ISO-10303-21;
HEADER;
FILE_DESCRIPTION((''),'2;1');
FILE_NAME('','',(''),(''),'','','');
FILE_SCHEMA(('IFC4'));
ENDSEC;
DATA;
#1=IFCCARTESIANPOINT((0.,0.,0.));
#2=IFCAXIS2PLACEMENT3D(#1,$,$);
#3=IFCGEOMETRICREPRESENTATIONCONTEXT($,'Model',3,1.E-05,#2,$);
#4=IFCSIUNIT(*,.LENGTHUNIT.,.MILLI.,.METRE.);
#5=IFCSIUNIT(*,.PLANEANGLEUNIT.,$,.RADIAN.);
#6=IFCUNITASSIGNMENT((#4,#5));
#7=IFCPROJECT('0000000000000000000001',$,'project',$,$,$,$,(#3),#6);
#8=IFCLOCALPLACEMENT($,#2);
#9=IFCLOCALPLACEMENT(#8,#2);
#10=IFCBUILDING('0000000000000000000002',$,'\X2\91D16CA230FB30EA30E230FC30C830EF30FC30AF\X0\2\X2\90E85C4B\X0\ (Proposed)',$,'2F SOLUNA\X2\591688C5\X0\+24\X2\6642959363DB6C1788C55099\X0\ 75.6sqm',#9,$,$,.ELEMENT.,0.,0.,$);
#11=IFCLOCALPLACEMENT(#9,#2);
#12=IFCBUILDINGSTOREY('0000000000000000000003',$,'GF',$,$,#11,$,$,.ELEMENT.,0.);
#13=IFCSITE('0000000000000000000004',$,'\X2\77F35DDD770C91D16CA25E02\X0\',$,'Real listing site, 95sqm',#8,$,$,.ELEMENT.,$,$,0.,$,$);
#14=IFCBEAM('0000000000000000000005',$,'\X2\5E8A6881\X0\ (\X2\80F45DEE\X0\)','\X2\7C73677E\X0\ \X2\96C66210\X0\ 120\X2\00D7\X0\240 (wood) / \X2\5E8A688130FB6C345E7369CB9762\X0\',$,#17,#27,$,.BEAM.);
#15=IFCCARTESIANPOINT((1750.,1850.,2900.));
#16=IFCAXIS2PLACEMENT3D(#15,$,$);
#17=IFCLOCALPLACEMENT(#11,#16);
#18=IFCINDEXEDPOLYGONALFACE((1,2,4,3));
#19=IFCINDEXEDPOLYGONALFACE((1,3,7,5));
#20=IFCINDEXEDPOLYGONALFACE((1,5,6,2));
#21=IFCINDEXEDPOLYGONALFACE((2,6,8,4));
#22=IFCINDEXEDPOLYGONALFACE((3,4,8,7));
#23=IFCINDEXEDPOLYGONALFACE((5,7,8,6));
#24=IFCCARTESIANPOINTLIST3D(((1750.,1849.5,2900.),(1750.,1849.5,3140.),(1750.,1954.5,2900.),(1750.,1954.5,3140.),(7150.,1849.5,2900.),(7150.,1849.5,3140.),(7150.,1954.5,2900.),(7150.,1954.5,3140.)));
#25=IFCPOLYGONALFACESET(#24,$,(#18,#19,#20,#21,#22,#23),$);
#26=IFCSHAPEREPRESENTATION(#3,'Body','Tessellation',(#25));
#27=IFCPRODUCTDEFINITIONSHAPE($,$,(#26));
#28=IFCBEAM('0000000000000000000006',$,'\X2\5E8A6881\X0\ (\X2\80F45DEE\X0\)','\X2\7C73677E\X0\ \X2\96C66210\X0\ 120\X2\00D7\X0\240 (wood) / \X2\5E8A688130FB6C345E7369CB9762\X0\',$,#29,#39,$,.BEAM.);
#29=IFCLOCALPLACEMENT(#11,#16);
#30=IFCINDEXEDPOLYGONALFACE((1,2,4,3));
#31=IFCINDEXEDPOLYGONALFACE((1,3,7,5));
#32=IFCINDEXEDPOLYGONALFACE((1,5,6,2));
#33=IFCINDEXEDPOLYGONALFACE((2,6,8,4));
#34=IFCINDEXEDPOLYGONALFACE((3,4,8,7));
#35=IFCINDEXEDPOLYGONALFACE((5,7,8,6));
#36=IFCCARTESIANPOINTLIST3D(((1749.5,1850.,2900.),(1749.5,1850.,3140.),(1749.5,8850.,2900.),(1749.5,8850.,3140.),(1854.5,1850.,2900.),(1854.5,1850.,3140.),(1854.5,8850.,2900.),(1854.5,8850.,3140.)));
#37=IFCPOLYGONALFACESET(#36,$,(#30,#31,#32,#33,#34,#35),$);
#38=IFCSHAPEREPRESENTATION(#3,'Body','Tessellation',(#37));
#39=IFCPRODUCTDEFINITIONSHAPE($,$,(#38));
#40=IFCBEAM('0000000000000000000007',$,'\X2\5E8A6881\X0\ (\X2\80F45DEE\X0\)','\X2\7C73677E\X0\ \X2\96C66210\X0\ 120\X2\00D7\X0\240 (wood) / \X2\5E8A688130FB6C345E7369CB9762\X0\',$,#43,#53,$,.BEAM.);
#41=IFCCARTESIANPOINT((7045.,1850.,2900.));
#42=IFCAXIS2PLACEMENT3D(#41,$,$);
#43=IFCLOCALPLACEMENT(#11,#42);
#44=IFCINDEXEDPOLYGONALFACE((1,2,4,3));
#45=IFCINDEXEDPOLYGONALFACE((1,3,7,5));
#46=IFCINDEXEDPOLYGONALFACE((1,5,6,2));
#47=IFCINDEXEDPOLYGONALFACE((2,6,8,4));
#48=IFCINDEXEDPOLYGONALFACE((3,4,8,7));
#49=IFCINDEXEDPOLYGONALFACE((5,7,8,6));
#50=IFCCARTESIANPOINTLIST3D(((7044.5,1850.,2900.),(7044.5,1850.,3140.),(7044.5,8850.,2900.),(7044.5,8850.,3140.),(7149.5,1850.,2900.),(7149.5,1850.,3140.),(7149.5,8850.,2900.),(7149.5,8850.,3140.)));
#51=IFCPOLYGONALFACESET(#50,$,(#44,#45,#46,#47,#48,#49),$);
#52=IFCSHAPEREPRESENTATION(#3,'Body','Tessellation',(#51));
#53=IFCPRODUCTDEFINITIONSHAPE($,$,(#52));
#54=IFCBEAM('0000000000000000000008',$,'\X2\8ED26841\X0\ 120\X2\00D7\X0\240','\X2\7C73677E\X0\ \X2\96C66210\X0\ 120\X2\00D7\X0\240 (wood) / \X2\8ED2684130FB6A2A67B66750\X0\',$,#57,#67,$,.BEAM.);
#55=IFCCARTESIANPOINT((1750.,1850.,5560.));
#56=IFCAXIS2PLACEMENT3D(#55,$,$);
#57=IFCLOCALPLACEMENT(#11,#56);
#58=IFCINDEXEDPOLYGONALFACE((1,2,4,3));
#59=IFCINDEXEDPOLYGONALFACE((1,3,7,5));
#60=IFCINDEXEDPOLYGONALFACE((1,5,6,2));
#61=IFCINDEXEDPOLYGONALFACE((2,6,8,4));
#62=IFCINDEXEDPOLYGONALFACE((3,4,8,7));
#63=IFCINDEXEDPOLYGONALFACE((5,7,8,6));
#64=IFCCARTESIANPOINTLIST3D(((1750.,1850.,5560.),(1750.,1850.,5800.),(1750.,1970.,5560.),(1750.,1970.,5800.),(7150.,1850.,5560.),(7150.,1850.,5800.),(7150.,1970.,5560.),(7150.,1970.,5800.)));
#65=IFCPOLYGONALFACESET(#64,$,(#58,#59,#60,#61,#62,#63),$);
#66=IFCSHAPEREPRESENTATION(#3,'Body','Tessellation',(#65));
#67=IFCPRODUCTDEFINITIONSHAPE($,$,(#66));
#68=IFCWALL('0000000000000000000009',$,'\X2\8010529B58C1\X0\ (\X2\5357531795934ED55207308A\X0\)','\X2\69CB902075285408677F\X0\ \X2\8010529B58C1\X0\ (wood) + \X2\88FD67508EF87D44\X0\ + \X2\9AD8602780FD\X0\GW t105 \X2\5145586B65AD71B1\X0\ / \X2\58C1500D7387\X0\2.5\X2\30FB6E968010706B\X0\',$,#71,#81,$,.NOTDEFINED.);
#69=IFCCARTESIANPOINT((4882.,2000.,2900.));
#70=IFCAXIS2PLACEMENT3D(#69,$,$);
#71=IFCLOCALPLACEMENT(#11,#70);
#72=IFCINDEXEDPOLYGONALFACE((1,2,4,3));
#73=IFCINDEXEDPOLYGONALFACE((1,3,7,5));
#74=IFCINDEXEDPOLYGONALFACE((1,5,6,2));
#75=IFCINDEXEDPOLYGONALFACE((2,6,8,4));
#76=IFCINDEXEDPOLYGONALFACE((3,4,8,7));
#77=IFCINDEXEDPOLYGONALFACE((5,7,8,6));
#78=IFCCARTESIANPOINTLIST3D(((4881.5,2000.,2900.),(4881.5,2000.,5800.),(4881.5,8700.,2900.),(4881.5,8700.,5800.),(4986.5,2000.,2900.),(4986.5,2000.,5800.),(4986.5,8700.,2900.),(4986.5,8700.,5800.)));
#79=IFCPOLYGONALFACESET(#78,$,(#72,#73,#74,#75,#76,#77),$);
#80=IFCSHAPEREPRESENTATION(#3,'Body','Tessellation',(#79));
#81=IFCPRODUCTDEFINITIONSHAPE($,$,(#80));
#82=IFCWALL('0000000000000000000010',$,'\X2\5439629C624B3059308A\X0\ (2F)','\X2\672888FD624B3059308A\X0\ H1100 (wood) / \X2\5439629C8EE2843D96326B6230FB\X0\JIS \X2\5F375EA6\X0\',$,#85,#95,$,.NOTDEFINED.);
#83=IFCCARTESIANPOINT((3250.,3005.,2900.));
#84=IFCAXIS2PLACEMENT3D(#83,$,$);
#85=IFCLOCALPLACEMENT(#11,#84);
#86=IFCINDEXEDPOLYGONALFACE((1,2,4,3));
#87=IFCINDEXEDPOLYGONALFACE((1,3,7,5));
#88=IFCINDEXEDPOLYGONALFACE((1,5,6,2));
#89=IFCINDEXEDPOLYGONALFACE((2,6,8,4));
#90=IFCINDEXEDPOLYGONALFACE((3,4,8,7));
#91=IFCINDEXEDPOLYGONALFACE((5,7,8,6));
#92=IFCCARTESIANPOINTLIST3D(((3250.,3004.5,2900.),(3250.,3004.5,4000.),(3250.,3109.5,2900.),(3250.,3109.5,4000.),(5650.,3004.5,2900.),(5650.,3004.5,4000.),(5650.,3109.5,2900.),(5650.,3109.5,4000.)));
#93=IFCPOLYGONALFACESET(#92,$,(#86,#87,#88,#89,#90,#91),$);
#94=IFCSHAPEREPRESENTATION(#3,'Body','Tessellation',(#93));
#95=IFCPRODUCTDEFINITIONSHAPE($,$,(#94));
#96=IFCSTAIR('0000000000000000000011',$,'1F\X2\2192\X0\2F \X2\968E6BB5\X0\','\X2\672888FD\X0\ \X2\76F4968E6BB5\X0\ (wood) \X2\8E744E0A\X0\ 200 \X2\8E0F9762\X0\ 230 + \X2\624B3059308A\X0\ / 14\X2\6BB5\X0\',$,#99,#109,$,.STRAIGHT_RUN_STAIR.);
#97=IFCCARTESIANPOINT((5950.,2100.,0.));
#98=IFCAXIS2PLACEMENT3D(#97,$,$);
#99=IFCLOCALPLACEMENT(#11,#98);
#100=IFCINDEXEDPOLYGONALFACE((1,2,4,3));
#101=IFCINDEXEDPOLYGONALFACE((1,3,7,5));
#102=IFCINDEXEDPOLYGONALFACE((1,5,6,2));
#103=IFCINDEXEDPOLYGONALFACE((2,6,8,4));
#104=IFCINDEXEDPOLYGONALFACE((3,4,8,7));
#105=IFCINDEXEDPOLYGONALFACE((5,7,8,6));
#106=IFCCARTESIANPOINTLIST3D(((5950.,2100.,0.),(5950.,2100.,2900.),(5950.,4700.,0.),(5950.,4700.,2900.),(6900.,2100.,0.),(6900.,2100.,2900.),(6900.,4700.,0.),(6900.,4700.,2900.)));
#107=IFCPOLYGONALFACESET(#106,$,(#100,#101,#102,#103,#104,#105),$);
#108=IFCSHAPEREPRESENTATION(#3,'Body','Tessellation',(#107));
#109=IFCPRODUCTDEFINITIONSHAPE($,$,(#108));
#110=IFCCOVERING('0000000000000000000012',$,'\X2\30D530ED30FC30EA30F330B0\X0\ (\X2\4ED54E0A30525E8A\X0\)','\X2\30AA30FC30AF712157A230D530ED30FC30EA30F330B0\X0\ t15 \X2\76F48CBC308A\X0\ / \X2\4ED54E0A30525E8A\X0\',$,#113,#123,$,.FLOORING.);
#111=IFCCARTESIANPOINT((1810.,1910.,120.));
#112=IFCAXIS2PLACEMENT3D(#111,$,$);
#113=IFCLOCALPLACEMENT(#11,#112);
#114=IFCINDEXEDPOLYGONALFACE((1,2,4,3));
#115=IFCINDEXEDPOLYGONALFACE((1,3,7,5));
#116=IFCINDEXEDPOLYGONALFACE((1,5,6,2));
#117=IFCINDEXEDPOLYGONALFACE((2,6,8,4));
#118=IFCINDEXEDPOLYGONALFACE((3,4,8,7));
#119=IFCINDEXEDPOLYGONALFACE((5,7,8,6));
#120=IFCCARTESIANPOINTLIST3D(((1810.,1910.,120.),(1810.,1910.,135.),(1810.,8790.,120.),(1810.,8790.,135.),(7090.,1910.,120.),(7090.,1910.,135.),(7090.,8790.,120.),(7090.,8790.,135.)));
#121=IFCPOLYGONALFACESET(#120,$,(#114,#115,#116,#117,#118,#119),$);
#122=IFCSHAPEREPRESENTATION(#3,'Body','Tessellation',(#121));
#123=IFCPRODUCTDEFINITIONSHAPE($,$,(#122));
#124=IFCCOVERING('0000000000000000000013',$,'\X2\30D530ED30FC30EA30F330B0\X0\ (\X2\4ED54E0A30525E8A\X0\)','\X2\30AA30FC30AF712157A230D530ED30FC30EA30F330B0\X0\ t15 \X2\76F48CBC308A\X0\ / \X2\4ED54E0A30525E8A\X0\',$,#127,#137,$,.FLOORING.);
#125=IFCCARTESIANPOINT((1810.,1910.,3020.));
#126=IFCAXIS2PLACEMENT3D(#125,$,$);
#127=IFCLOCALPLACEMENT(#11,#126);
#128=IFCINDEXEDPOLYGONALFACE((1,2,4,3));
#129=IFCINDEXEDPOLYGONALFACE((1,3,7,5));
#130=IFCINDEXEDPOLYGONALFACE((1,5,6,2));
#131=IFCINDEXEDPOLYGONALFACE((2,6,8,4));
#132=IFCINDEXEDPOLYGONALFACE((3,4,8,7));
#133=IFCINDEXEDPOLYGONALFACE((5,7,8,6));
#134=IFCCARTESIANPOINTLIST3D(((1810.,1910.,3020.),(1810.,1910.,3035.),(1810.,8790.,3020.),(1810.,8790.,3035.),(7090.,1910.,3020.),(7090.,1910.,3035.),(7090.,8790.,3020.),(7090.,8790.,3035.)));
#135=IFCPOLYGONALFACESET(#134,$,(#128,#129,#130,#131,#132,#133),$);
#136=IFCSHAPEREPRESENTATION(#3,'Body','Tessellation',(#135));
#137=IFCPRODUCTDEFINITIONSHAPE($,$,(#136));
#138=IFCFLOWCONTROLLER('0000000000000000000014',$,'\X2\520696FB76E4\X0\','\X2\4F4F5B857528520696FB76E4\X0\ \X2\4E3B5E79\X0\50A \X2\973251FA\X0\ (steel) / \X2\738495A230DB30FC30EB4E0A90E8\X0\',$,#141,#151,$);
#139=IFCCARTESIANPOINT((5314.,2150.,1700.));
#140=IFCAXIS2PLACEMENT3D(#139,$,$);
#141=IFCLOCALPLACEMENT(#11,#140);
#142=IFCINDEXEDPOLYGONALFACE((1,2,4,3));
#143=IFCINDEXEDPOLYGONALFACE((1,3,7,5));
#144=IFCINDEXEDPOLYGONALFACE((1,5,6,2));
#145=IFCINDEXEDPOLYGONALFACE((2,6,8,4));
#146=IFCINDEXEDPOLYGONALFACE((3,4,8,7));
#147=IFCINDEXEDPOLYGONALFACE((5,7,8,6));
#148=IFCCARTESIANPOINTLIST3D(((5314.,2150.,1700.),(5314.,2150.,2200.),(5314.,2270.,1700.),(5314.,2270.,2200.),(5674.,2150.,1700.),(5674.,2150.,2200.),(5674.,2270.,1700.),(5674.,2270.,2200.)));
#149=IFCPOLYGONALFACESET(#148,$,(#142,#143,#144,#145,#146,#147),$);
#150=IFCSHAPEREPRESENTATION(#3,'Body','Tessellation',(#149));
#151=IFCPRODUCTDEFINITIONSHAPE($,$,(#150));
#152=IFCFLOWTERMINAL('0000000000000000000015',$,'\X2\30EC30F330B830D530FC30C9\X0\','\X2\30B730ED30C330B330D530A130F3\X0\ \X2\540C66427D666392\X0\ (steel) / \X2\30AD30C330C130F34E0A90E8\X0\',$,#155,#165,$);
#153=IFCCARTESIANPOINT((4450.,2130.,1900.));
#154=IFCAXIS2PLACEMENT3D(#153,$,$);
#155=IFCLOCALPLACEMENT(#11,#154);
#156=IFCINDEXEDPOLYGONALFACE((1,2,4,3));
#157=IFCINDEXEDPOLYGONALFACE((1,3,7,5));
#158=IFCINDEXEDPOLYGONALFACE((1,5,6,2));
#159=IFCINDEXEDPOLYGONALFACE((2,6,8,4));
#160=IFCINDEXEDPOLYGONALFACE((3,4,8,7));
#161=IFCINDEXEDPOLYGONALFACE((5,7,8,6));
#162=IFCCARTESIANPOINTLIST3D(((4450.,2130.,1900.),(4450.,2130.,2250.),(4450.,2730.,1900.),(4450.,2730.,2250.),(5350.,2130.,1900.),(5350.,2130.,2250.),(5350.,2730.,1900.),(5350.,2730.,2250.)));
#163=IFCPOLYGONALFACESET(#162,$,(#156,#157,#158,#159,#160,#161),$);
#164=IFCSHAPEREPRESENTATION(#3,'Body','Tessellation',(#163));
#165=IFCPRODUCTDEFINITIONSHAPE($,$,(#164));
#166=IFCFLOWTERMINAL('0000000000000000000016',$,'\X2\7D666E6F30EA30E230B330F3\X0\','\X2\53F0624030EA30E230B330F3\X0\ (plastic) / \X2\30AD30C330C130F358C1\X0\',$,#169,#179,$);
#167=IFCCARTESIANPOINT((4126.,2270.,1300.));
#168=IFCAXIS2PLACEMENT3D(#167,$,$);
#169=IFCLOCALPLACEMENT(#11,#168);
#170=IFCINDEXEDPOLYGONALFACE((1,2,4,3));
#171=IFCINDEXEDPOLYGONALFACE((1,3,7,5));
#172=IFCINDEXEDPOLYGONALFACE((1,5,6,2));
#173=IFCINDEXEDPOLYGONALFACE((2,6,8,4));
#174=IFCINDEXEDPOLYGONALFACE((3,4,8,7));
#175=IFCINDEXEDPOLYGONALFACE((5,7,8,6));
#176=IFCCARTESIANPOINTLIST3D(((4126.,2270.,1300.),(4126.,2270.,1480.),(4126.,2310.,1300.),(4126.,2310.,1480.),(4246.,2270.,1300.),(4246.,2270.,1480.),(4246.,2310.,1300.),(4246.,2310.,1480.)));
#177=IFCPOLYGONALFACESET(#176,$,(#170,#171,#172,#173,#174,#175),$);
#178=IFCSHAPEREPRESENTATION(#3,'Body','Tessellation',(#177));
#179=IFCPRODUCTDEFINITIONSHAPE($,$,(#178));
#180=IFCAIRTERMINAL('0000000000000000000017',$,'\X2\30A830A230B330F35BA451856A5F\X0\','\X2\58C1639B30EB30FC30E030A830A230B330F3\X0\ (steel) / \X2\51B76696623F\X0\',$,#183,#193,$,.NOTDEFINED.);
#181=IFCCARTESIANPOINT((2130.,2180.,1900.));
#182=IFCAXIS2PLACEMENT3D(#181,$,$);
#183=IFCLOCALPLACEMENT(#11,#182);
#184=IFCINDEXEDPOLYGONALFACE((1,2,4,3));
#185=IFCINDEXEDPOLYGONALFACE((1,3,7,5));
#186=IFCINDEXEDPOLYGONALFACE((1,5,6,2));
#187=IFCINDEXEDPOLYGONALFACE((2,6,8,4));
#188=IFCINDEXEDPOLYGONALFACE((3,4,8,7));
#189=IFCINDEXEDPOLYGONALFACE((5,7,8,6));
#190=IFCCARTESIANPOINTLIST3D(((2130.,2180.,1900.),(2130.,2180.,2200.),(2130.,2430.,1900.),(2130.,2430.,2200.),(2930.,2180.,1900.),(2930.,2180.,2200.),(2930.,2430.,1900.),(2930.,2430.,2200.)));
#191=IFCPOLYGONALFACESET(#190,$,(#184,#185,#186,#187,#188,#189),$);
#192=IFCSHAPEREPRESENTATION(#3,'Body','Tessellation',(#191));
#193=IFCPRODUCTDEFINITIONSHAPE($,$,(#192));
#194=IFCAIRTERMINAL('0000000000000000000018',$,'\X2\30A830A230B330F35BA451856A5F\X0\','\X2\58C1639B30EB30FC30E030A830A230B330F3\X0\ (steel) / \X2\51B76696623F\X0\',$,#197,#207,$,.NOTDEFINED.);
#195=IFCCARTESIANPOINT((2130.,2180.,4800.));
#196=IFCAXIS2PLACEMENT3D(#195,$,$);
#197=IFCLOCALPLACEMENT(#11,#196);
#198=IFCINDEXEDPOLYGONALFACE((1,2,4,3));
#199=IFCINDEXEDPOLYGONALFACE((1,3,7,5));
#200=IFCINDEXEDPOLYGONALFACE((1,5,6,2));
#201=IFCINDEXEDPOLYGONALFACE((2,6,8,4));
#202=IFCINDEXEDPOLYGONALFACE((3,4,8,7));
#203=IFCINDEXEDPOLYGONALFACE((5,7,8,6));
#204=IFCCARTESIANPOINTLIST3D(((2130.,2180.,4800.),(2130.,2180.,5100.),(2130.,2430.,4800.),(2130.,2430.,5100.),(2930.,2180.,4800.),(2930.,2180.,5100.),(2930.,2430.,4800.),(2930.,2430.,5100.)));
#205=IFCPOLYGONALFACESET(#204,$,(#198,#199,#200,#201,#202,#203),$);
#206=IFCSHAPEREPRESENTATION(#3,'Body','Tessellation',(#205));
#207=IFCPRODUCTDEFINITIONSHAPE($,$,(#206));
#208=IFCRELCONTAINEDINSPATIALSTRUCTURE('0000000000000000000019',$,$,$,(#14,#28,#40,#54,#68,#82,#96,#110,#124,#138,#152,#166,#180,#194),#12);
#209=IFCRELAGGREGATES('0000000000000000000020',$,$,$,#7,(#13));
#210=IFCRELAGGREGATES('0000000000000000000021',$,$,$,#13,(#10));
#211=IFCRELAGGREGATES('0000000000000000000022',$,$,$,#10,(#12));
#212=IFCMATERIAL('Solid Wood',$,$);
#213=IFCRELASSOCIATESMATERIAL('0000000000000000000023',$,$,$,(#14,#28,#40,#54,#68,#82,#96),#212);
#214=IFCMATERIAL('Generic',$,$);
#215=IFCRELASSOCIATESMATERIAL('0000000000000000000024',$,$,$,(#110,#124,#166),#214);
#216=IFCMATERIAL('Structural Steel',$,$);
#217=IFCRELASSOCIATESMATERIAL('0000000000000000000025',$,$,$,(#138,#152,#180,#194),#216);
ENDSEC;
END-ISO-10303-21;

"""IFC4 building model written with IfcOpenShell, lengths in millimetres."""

from ifc_helpers import new_model, si_unit, frame, frame_2d, origin, place, context, project, spatial, rectangle, extrude, material, element, save


model = new_model("IFC4")

# Units and contexts
model_context = context("Model", 3, precision=1e-05, world=origin())
ifc_project = project(units=[si_unit("LENGTHUNIT", "METRE", prefix="MILLI"), si_unit("PLANEANGLEUNIT", "RADIAN")], contexts=[model_context])

# Site, building, storey
site_placement = place(None, origin())
site = spatial("IfcSite", under=ifc_project, at=site_placement, Name="石川県金沢市", ObjectType="Real listing site, 95sqm", CompositionType="ELEMENT", RefElevation=0.0)
building_placement = place(site_placement, origin())
building = spatial("IfcBuilding", under=site, at=building_placement, Name="金沢・リモートワーク2部屋 (Proposed)", ObjectType="2F SOLUNA外装+24時間換気装備 75.6sqm", CompositionType="ELEMENT", ElevationOfRefHeight=0.0, ElevationOfTerrain=0.0)
storey_placement = place(building_placement, origin())
storey = spatial("IfcBuildingStorey", under=building, at=storey_placement, Name="GF", CompositionType="ELEMENT", Elevation=0.0)

# Shared definitions
ifc_material_1 = material(Name="Solid Wood")

# Beams
beam_1_placement = place(storey_placement, frame((1750.0, 1850.0, 2900.0)))
element("IfcBeam", 1, at=beam_1_placement, inside=storey, material=ifc_material_1, Name="床梁 (胴差)", Description="米松 集成 120×240 (wood) / 床梁・水平構面", PredefinedType="BEAM", context=model_context, shape_type="SweptSolid", body=[
    extrude(rectangle(XDim=5400.0, YDim=105.0, at=frame_2d((2700.0, 52.0))), frame((1750.0, 1850.0, 2900.0)), (0.0, 0.0, 1.0), 240.0),
])
beam_2_placement = place(storey_placement, frame((1750.0, 1850.0, 2900.0)))
element("IfcBeam", 2, at=beam_2_placement, inside=storey, material=ifc_material_1, Name="床梁 (胴差)", Description="米松 集成 120×240 (wood) / 床梁・水平構面", PredefinedType="BEAM", context=model_context, shape_type="SweptSolid", body=[
    extrude(rectangle(XDim=105.0, YDim=7000.0, at=frame_2d((52.0, 3500.0))), frame((1750.0, 1850.0, 2900.0)), (0.0, 0.0, 1.0), 240.0),
])
beam_3_placement = place(storey_placement, frame((7045.0, 1850.0, 2900.0)))
element("IfcBeam", 3, at=beam_3_placement, inside=storey, material=ifc_material_1, Name="床梁 (胴差)", Description="米松 集成 120×240 (wood) / 床梁・水平構面", PredefinedType="BEAM", context=model_context, shape_type="SweptSolid", body=[
    extrude(rectangle(XDim=105.0, YDim=7000.0, at=frame_2d((52.0, 3500.0))), frame((7045.0, 1850.0, 2900.0)), (0.0, 0.0, 1.0), 240.0),
])
beam_4_placement = place(storey_placement, frame((1750.0, 1850.0, 5560.0)))
element("IfcBeam", 4, at=beam_4_placement, inside=storey, material=ifc_material_1, Name="軒桁 120×240", Description="米松 集成 120×240 (wood) / 軒桁・横架材", PredefinedType="BEAM", context=model_context, shape_type="SweptSolid", body=[
    extrude(rectangle(XDim=5400.0, YDim=120.0, at=frame_2d((2700.0, 60.0))), frame((1750.0, 1850.0, 5560.0)), (0.0, 0.0, 1.0), 240.0),
])

# Walls
wall_1_placement = place(storey_placement, frame((4882.0, 2000.0, 2900.0)))
element("IfcWall", 5, at=wall_1_placement, inside=storey, material=ifc_material_1, Name="耐力壁 (南北間仕切り)", Description="構造用合板 耐力壁 (wood) + 製材軸組 + 高性能GW t105 充填断熱 / 壁倍率2.5・準耐火", PredefinedType="NOTDEFINED", context=model_context, shape_type="SweptSolid", body=[
    extrude(rectangle(XDim=105.0, YDim=6700.0, at=frame_2d((52.0, 3350.0))), frame((4882.0, 2000.0, 2900.0)), (0.0, 0.0, 1.0), 2900.0),
])
wall_2_placement = place(storey_placement, frame((3250.0, 3005.0, 2900.0)))
element("IfcWall", 6, at=wall_2_placement, inside=storey, material=ifc_material_1, Name="吹抜手すり (2F)", Description="木製手すり H1100 (wood) / 吹抜転落防止・JIS 強度", PredefinedType="NOTDEFINED", context=model_context, shape_type="SweptSolid", body=[
    extrude(rectangle(XDim=2400.0, YDim=105.0, at=frame_2d((1200.0, 52.0))), frame((3250.0, 3005.0, 2900.0)), (0.0, 0.0, 1.0), 1100.0),
])

# Stair
stair_placement = place(storey_placement, frame((5950.0, 2100.0, 0.0)))
element("IfcStair", 7, at=stair_placement, inside=storey, material=ifc_material_1, Name="1F→2F 階段", Description="木製 直階段 (wood) 蹴上 200 踏面 230 + 手すり / 14段", PredefinedType="STRAIGHT_RUN_STAIR", context=model_context, shape_type="SweptSolid", body=[
    extrude(rectangle(XDim=950.0, YDim=2600.0, at=frame_2d((475.0, 1300.0))), frame((5950.0, 2100.0, 0.0)), (0.0, 0.0, 1.0), 2900.0),
])

# Coverings
ifc_material_2 = material(Name="Generic")
covering_1_placement = place(storey_placement, frame((1810.0, 1910.0, 120.0)))
element("IfcCovering", 8, at=covering_1_placement, inside=storey, material=ifc_material_2, Name="フローリング (仕上げ床)", Description="オーク無垢フローリング t15 直貼り / 仕上げ床", PredefinedType="FLOORING", context=model_context, shape_type="SweptSolid", body=[
    extrude(rectangle(XDim=5280.0, YDim=6880.0, at=frame_2d((2640.0, 3440.0))), frame((1810.0, 1910.0, 120.0)), (0.0, 0.0, 1.0), 15.0),
])
covering_2_placement = place(storey_placement, frame((1810.0, 1910.0, 3020.0)))
element("IfcCovering", 9, at=covering_2_placement, inside=storey, material=ifc_material_2, Name="フローリング (仕上げ床)", Description="オーク無垢フローリング t15 直貼り / 仕上げ床", PredefinedType="FLOORING", context=model_context, shape_type="SweptSolid", body=[
    extrude(rectangle(XDim=5280.0, YDim=6880.0, at=frame_2d((2640.0, 3440.0))), frame((1810.0, 1910.0, 3020.0)), (0.0, 0.0, 1.0), 15.0),
])

# Flow controller
ifc_material_3 = material(Name="Structural Steel")
flow_controller_placement = place(storey_placement, frame((5314.0, 2150.0, 1700.0)))
element("IfcFlowController", 10, at=flow_controller_placement, inside=storey, material=ifc_material_3, Name="分電盤", Description="住宅用分電盤 主幹50A 露出 (steel) / 玄関ホール上部", context=model_context, shape_type="SweptSolid", body=[
    extrude(rectangle(XDim=360.0, YDim=120.0, at=frame_2d((180.0, 60.0))), frame((5314.0, 2150.0, 1700.0)), (0.0, 0.0, 1.0), 500.0),
])

# Flow terminals
flow_terminal_1_placement = place(storey_placement, frame((4450.0, 2130.0, 1900.0)))
element("IfcFlowTerminal", 11, at=flow_terminal_1_placement, inside=storey, material=ifc_material_3, Name="レンジフード", Description="シロッコファン 同時給排 (steel) / キッチン上部", context=model_context, shape_type="SweptSolid", body=[
    extrude(rectangle(XDim=900.0, YDim=600.0, at=frame_2d((450.0, 300.0))), frame((4450.0, 2130.0, 1900.0)), (0.0, 0.0, 1.0), 350.0),
])
flow_terminal_2_placement = place(storey_placement, frame((4126.0, 2270.0, 1300.0)))
element("IfcFlowTerminal", 12, at=flow_terminal_2_placement, inside=storey, material=ifc_material_2, Name="給湯リモコン", Description="台所リモコン (plastic) / キッチン壁", context=model_context, shape_type="SweptSolid", body=[
    extrude(rectangle(XDim=120.0, YDim=40.0, at=frame_2d((60.0, 20.0))), frame((4126.0, 2270.0, 1300.0)), (0.0, 0.0, 1.0), 180.0),
])

# Air terminals
air_terminal_1_placement = place(storey_placement, frame((2130.0, 2180.0, 1900.0)))
element("IfcAirTerminal", 13, at=air_terminal_1_placement, inside=storey, material=ifc_material_3, Name="エアコン室内機", Description="壁掛ルームエアコン (steel) / 冷暖房", PredefinedType="NOTDEFINED", context=model_context, shape_type="SweptSolid", body=[
    extrude(rectangle(XDim=800.0, YDim=250.0, at=frame_2d((400.0, 125.0))), frame((2130.0, 2180.0, 1900.0)), (0.0, 0.0, 1.0), 300.0),
])
air_terminal_2_placement = place(storey_placement, frame((2130.0, 2180.0, 4800.0)))
element("IfcAirTerminal", 14, at=air_terminal_2_placement, inside=storey, material=ifc_material_3, Name="エアコン室内機", Description="壁掛ルームエアコン (steel) / 冷暖房", PredefinedType="NOTDEFINED", context=model_context, shape_type="SweptSolid", body=[
    extrude(rectangle(XDim=800.0, YDim=250.0, at=frame_2d((400.0, 125.0))), frame((2130.0, 2180.0, 4800.0)), (0.0, 0.0, 1.0), 300.0),
])

save(model, "model.ifc")
